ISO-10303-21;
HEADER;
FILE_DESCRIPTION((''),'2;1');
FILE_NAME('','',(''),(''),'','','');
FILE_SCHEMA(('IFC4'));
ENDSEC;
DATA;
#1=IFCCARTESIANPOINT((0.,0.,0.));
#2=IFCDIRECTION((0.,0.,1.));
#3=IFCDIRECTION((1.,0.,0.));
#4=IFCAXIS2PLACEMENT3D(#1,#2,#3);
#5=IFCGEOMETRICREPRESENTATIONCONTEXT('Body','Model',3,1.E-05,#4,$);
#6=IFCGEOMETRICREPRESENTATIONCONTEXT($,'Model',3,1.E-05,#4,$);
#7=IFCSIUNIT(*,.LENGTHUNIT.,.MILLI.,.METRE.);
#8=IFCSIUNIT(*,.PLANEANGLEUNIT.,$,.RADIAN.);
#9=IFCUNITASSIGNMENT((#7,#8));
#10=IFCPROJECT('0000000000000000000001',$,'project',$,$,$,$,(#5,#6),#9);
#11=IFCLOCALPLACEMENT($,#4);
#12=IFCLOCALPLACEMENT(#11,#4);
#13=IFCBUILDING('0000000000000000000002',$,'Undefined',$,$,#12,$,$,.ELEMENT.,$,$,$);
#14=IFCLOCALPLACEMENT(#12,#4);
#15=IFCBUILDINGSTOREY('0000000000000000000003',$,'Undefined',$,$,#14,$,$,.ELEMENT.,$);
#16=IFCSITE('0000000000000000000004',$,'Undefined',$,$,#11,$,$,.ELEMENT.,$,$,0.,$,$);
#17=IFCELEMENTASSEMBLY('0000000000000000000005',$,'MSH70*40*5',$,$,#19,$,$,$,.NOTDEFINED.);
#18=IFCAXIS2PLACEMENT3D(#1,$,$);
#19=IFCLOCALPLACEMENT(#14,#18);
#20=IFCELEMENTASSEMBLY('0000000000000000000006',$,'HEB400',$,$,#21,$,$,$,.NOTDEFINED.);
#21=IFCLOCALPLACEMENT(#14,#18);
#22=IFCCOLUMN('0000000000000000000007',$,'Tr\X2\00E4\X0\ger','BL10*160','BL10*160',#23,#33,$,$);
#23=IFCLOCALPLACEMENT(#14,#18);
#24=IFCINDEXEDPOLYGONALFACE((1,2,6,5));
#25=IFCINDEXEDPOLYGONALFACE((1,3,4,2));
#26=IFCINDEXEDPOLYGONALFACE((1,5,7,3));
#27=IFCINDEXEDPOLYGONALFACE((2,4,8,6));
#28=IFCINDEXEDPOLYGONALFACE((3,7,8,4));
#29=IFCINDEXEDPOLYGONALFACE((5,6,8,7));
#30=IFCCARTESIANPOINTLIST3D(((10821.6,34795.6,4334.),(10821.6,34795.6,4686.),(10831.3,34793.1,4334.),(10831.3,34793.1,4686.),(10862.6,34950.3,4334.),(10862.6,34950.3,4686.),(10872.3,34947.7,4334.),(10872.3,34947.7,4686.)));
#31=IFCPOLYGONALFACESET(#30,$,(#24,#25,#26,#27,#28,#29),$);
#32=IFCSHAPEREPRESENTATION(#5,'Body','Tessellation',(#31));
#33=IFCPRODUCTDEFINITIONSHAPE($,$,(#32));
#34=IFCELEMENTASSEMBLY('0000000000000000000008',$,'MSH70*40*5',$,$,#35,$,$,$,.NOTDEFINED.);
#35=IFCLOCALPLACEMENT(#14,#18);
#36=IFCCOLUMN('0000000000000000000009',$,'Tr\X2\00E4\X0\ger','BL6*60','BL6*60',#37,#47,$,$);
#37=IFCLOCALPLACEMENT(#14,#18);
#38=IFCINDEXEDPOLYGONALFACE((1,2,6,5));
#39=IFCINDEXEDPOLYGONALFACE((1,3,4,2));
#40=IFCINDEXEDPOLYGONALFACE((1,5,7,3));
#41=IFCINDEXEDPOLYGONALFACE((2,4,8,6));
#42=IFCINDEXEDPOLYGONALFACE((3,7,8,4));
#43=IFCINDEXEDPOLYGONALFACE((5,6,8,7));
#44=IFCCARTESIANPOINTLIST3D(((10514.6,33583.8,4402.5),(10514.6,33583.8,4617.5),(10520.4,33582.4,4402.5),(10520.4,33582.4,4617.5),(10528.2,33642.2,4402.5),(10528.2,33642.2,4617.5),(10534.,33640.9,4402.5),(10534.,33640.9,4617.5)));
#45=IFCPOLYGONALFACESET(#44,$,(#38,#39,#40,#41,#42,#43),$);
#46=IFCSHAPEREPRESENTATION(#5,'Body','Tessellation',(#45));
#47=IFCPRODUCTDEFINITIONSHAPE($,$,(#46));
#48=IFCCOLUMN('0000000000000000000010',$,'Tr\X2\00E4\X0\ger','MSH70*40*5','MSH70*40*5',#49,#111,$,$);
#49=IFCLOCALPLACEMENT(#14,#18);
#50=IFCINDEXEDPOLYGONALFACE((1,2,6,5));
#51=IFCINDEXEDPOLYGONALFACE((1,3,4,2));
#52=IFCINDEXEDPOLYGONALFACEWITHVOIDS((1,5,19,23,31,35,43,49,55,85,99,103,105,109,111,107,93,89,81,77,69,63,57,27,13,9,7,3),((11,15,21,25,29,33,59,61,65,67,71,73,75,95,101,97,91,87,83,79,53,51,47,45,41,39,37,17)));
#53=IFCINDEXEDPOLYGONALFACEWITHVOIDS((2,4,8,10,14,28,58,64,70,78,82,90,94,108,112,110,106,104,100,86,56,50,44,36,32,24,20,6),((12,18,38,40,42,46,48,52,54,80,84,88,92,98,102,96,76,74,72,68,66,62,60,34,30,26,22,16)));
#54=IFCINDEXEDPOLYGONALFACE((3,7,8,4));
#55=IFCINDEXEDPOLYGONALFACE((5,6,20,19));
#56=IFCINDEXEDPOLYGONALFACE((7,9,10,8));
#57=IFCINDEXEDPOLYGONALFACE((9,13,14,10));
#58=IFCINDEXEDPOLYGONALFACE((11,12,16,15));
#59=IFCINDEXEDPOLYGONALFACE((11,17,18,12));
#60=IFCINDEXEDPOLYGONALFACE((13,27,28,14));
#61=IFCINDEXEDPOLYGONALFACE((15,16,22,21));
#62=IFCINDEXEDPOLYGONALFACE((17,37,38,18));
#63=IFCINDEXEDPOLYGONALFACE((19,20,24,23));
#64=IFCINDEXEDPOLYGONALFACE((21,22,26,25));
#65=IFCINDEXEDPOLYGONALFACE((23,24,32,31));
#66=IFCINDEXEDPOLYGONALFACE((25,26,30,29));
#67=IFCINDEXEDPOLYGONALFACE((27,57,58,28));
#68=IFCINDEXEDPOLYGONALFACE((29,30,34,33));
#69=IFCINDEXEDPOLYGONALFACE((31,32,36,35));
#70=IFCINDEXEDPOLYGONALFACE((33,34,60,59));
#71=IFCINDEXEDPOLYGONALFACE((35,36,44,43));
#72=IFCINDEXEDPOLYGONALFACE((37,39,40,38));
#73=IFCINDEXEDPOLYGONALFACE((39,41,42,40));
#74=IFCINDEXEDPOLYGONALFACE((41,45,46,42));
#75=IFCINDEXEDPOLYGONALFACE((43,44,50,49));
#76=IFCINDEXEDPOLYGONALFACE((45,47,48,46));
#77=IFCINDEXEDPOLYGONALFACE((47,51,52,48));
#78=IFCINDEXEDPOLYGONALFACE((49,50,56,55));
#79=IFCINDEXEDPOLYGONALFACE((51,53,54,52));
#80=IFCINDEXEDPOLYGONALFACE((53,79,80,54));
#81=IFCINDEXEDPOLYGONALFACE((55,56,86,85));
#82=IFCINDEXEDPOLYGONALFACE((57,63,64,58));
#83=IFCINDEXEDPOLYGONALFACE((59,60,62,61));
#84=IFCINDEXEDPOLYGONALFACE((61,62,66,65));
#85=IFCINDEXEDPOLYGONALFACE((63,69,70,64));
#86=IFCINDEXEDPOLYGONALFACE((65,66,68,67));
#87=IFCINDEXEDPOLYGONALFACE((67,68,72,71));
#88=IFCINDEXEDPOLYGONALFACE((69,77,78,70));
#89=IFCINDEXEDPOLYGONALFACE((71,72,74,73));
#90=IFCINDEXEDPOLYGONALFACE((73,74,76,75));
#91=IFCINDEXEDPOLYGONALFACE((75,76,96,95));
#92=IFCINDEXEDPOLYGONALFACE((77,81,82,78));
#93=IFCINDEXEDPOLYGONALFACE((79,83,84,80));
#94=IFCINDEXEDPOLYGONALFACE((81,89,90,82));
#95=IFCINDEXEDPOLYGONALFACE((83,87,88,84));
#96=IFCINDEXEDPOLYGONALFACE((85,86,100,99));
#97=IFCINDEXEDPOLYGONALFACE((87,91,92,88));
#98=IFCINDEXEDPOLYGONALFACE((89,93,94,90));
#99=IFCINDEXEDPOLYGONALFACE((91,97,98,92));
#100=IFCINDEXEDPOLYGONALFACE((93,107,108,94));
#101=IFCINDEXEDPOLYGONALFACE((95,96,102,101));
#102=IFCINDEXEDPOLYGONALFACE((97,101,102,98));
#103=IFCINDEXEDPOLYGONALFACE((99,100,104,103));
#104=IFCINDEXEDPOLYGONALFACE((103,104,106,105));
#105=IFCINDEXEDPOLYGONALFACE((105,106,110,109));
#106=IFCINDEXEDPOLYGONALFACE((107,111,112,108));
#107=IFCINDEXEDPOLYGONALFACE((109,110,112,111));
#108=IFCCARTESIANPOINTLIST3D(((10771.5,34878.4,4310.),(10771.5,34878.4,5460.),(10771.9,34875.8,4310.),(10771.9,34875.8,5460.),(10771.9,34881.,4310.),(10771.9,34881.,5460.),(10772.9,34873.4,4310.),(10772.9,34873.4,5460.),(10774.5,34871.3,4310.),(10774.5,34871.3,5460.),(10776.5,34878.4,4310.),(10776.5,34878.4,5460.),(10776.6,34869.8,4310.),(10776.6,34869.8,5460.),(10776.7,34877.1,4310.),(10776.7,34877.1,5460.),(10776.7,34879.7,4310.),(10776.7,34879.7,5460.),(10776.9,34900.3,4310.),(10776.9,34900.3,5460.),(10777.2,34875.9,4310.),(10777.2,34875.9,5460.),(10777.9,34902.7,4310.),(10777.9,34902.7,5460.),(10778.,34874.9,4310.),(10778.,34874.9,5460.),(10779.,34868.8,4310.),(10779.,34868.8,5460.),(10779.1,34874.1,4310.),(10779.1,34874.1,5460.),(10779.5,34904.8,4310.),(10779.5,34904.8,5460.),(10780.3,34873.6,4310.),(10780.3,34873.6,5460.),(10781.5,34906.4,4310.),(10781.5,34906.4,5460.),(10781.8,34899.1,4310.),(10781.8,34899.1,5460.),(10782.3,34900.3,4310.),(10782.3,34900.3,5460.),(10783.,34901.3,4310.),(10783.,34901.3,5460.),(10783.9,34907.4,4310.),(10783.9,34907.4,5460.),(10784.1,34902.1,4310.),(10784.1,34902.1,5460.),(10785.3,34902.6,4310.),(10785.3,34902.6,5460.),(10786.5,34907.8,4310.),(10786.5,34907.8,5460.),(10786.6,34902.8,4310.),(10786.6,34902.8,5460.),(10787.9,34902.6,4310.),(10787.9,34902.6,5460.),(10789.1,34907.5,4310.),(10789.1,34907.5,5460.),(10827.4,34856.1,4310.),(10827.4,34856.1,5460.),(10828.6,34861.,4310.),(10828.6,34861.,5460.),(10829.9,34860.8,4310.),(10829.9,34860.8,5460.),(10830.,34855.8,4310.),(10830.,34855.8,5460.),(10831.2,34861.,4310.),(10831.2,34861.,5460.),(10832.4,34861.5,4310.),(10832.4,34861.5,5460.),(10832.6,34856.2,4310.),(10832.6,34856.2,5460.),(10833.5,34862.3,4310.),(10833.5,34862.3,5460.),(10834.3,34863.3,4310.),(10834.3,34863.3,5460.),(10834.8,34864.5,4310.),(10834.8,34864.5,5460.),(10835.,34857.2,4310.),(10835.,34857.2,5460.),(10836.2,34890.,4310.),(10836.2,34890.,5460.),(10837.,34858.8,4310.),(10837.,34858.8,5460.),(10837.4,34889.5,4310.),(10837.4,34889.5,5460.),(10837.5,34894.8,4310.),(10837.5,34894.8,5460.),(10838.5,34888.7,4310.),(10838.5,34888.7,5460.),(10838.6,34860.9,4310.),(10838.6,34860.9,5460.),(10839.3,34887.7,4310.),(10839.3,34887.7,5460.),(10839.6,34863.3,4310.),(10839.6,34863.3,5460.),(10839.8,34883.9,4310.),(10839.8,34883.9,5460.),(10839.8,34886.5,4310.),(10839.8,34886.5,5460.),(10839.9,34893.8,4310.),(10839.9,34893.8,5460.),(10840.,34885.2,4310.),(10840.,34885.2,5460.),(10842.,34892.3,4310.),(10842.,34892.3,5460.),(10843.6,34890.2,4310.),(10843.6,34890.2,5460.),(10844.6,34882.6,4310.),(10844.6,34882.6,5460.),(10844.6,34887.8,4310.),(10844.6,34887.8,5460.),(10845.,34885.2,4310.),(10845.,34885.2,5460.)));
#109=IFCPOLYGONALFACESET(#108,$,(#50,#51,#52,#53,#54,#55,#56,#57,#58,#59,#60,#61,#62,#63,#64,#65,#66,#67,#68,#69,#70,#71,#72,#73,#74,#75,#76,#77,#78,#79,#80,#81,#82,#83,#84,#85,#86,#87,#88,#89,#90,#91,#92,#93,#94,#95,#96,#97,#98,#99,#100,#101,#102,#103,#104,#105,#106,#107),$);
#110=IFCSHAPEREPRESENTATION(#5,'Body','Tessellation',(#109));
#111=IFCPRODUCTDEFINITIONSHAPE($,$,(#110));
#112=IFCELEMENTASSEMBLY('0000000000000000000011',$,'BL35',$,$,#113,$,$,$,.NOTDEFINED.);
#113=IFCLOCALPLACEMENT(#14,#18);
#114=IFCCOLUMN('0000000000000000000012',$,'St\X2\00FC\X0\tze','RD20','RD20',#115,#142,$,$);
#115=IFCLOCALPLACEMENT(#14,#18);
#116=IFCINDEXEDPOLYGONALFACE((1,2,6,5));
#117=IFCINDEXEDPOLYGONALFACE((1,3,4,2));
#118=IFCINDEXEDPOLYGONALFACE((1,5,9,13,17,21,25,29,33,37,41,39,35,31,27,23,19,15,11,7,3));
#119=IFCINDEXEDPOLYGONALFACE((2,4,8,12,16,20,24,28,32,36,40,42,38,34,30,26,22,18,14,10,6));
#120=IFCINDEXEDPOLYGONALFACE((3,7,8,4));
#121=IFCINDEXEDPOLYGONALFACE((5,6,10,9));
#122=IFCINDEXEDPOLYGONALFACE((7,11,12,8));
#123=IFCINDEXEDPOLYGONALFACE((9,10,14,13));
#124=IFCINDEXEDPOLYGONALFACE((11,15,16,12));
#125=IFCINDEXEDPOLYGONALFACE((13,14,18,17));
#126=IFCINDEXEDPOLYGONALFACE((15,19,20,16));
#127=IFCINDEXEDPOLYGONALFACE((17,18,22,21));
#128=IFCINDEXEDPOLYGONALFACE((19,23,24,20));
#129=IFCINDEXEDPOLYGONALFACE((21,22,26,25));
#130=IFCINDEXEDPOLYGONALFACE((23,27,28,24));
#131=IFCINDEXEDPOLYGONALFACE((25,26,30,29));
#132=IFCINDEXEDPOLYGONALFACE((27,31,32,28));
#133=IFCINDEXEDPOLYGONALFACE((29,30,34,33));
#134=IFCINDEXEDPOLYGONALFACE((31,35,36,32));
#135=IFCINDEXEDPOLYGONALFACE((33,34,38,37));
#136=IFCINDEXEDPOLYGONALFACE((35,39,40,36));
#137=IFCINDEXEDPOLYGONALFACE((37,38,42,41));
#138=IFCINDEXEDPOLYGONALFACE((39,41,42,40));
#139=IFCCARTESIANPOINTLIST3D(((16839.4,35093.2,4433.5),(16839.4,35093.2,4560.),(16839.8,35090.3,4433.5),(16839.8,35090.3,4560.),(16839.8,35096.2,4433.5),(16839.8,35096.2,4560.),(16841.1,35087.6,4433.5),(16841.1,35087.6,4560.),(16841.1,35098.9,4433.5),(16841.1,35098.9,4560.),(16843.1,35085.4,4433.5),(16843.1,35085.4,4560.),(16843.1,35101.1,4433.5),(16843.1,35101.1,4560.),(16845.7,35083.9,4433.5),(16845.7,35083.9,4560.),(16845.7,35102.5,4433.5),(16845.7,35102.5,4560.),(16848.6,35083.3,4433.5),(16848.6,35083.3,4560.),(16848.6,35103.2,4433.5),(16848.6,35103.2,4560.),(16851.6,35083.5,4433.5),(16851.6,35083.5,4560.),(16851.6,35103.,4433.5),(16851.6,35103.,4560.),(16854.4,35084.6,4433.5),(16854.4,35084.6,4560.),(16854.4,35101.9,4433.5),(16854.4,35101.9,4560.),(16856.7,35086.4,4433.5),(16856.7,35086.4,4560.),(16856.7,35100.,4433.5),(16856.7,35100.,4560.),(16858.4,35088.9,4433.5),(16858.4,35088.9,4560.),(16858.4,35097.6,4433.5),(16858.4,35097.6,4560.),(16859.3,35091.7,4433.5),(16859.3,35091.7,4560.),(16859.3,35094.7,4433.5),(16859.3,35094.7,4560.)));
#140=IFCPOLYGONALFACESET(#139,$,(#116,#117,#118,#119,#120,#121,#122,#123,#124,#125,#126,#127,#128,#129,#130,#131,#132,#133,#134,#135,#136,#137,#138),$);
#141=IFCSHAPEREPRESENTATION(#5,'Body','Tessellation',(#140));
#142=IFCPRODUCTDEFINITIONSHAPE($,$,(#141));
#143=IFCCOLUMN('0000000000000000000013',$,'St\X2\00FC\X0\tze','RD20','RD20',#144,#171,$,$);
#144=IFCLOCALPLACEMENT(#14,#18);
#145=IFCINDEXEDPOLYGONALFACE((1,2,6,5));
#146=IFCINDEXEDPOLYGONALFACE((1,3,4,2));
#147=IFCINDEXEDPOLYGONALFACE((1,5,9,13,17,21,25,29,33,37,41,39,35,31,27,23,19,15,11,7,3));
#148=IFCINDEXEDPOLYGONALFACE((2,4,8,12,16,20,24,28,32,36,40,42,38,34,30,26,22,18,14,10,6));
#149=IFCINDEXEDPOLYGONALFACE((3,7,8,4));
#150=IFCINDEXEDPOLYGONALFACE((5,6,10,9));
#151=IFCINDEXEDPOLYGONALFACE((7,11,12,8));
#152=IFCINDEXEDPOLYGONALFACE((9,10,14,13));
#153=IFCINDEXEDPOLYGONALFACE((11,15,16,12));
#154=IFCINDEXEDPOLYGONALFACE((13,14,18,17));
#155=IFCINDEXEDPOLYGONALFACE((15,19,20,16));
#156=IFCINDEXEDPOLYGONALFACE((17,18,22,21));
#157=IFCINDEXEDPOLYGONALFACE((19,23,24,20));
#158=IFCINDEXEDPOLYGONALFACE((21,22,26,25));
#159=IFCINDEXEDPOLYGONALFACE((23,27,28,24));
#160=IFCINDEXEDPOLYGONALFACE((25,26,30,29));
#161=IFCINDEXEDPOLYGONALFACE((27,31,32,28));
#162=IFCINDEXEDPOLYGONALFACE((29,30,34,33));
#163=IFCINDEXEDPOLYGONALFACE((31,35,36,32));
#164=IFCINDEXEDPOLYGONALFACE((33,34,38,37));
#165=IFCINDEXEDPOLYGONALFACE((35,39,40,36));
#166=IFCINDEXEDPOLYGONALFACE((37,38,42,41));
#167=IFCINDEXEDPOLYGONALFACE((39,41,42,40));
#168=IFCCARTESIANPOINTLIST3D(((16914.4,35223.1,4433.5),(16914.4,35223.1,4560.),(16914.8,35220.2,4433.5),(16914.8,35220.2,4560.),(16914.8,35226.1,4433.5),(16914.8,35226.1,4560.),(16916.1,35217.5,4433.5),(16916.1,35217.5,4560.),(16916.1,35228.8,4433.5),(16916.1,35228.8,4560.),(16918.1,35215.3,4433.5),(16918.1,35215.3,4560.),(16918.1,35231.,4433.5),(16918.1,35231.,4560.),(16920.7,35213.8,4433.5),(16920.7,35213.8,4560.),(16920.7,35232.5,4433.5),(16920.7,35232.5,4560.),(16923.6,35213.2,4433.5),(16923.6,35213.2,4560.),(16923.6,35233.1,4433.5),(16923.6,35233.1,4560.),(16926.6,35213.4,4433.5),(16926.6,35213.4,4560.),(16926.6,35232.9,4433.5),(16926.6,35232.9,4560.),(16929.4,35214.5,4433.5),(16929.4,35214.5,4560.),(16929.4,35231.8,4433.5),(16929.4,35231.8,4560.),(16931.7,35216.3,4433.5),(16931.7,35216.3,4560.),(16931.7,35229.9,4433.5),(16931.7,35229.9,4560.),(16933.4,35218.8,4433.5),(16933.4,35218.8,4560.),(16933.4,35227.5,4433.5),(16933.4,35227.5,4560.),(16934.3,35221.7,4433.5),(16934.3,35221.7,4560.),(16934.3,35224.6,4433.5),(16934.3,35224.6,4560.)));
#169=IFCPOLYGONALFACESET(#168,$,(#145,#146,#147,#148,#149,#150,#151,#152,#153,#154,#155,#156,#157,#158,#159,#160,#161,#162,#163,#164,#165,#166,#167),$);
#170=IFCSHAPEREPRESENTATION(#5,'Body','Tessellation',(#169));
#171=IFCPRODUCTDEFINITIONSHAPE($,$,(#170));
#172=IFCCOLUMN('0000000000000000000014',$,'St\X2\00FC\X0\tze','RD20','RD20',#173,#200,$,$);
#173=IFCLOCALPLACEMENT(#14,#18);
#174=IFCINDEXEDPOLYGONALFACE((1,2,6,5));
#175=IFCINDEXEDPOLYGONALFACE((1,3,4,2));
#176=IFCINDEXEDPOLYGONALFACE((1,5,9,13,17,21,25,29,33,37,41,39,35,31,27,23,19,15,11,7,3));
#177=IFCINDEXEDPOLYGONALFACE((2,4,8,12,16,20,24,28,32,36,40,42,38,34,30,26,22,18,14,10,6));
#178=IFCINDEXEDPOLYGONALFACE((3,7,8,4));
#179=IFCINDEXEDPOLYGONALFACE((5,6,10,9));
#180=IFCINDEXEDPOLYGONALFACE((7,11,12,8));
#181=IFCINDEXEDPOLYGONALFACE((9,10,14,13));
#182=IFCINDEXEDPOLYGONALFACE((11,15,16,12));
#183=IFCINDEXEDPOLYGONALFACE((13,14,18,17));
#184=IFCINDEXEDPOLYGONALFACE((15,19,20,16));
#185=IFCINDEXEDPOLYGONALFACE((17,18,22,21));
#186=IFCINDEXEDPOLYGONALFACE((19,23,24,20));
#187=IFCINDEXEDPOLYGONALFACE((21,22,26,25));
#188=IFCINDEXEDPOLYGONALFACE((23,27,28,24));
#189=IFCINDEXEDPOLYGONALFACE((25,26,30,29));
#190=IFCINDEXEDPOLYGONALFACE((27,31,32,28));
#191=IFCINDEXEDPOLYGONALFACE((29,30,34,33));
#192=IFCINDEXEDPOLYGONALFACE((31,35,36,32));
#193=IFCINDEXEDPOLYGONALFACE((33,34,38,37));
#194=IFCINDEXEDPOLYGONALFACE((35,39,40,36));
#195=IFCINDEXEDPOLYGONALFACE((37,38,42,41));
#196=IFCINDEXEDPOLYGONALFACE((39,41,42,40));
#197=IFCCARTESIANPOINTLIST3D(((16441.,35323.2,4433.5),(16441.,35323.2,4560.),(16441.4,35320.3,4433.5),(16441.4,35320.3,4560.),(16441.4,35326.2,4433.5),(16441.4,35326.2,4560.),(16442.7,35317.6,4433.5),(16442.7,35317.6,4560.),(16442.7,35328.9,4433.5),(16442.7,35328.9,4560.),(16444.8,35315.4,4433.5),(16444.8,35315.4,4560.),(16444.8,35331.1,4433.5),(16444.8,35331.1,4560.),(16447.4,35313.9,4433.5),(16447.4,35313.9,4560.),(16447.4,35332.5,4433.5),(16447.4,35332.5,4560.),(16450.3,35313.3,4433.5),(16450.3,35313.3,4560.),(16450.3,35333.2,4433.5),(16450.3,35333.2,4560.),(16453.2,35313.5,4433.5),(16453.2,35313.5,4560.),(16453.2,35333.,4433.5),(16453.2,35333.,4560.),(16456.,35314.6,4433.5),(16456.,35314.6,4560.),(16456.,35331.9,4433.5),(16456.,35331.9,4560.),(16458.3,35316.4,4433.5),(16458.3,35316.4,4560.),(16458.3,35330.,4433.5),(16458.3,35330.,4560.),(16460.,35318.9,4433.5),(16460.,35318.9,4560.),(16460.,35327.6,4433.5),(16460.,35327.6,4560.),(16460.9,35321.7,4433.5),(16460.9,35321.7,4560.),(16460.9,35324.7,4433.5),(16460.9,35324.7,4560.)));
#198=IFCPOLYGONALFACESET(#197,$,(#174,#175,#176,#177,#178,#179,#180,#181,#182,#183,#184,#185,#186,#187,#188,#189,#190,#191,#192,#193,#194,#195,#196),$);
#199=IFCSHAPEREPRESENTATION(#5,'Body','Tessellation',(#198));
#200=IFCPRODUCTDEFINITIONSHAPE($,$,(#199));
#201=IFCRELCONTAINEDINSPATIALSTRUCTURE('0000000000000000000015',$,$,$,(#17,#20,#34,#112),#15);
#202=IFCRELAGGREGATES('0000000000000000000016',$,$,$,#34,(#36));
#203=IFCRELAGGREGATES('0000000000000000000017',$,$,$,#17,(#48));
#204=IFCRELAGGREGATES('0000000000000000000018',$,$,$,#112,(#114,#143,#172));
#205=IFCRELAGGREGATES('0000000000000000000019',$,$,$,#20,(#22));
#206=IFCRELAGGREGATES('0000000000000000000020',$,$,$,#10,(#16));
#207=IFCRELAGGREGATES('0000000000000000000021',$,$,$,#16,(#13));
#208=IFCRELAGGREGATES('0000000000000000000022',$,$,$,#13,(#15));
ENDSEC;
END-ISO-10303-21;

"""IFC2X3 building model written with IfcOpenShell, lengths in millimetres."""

from ifc_helpers import new_model, si_unit, frame, origin_with_axes, origin_2d_with_axis, place, context, project, spatial, rectangle, hollow_rectangle, circle, extrude, element, aggregate, save


model = new_model("IFC2X3")

# Units and contexts
model_context_1 = context("Model", 3, precision=1e-05, world=origin_with_axes(), identifier="Body")
model_context_2 = context("Model", 3, precision=1e-05, world=origin_with_axes())
ifc_project = project(units=[si_unit("LENGTHUNIT", "METRE", prefix="MILLI"), si_unit("PLANEANGLEUNIT", "RADIAN")], contexts=[model_context_1, model_context_2])

# Site, building, storey
site_placement = place(None, origin_with_axes())
site = spatial("IfcSite", under=ifc_project, at=site_placement, Name="Undefined", CompositionType="ELEMENT", RefElevation=0.0)
building_placement = place(site_placement, origin_with_axes())
building = spatial("IfcBuilding", under=site, at=building_placement, Name="Undefined", CompositionType="ELEMENT")
storey_placement = place(building_placement, origin_with_axes())
storey = spatial("IfcBuildingStorey", under=building, at=storey_placement, Name="Undefined", CompositionType="ELEMENT")

# Element assembly
assembly_1 = element("IfcElementAssembly", 1, inside=storey, Name="MSH70*40*5", PredefinedType="NOTDEFINED")

# Element assemblies, columns
assembly_2 = element("IfcElementAssembly", 2, inside=storey, Name="HEB400", PredefinedType="NOTDEFINED")
column_1_placement = place(storey_placement, frame((10847.0, 34871.7, 4334.0), z_axis=(0.0, 0.0, 1.0), x_axis=(1.0, 0.0, 0.0)))
column_1 = element("IfcColumn", 3, at=column_1_placement, Name="Träger", Description="BL10*160", ObjectType="BL10*160", context=model_context_1, shape_type="SweptSolid", body=[
    extrude(rectangle(XDim=10.0, YDim=160.0, at=origin_2d_with_axis()), frame((0.0, 0.0, 352.0), z_axis=(0.0, 0.0, -1.0), x_axis=(-0.9666, 0.256289, 0.0)), (0.0, 0.0, 1.0), 352.0),
])
assembly_3 = element("IfcElementAssembly", 4, inside=storey, Name="MSH70*40*5", PredefinedType="NOTDEFINED")
column_2_placement = place(storey_placement, frame((10524.3, 33612.3, 4402.5), z_axis=(0.0, 0.0, 1.0), x_axis=(1.0, 0.0, 0.0)))
column_2 = element("IfcColumn", 5, at=column_2_placement, Name="Träger", Description="BL6*60", ObjectType="BL6*60", context=model_context_1, shape_type="SweptSolid", body=[
    extrude(rectangle(XDim=6.0, YDim=60.0, at=origin_2d_with_axis()), frame((0.0, 0.0, 215.0), z_axis=(0.0, 0.0, -1.0), x_axis=(-0.973976, 0.226651, 0.0)), (0.0, 0.0, 1.0), 215.0),
])
aggregate(assembly_3, [column_2])

# Column
column_3_placement = place(storey_placement, frame((10808.3, 34881.8, 4310.0), z_axis=(0.0, 0.0, 1.0), x_axis=(1.0, 0.0, 0.0)))
column_3 = element("IfcColumn", 6, at=column_3_placement, Name="Träger", Description="MSH70*40*5", ObjectType="MSH70*40*5", context=model_context_1, shape_type="SweptSolid", body=[
    extrude(hollow_rectangle(XDim=40.0, YDim=70.0, WallThickness=5.0, InnerFilletRadius=5.0, OuterFilletRadius=10.0, at=origin_2d_with_axis()), frame((0.0, 0.0, 1150.0), z_axis=(0.0, 0.0, -1.0), x_axis=(-0.252914, -0.967489, 0.0)), (0.0, 0.0, 1.0), 1150.0),
])
aggregate(assembly_1, [column_3])

# Element assembly, columns
assembly_4 = element("IfcElementAssembly", 7, inside=storey, Name="BL35", PredefinedType="NOTDEFINED")
column_4_placement = place(storey_placement, frame((16849.4, 35093.2, 4433.5), z_axis=(0.0, 0.0, 1.0), x_axis=(1.0, 0.0, 0.0)))
column_4 = element("IfcColumn", 8, at=column_4_placement, Name="Stütze", Description="RD20", ObjectType="RD20", context=model_context_1, shape_type="SweptSolid", body=[
    extrude(circle(Radius=10.0, at=origin_2d_with_axis()), frame((0.0, 0.0, 126.5), z_axis=(0.0, 0.0, -1.0), x_axis=(0.5, 0.866025, 0.0)), (0.0, 0.0, 1.0), 126.5),
])
column_5_placement = place(storey_placement, frame((16924.4, 35223.1, 4433.5), z_axis=(0.0, 0.0, 1.0), x_axis=(1.0, 0.0, 0.0)))
column_5 = element("IfcColumn", 9, at=column_5_placement, Name="Stütze", Description="RD20", ObjectType="RD20", context=model_context_1, shape_type="SweptSolid", body=[
    extrude(circle(Radius=10.0, at=origin_2d_with_axis()), frame((0.0, 0.0, 126.5), z_axis=(0.0, 0.0, -1.0), x_axis=(0.5, 0.866025, 0.0)), (0.0, 0.0, 1.0), 126.5),
])
column_6_placement = place(storey_placement, frame((16451.0, 35323.2, 4433.5), z_axis=(0.0, 0.0, 1.0), x_axis=(1.0, 0.0, 0.0)))
column_6 = element("IfcColumn", 10, at=column_6_placement, Name="Stütze", Description="RD20", ObjectType="RD20", context=model_context_1, shape_type="SweptSolid", body=[
    extrude(circle(Radius=10.0, at=origin_2d_with_axis()), frame((0.0, 0.0, 126.5), z_axis=(0.0, 0.0, -1.0), x_axis=(0.5, 0.866025, 0.0)), (0.0, 0.0, 1.0), 126.5),
])
aggregate(assembly_4, [column_4, column_5, column_6])

aggregate(assembly_2, [column_1])

save(model, "model.ifc")
